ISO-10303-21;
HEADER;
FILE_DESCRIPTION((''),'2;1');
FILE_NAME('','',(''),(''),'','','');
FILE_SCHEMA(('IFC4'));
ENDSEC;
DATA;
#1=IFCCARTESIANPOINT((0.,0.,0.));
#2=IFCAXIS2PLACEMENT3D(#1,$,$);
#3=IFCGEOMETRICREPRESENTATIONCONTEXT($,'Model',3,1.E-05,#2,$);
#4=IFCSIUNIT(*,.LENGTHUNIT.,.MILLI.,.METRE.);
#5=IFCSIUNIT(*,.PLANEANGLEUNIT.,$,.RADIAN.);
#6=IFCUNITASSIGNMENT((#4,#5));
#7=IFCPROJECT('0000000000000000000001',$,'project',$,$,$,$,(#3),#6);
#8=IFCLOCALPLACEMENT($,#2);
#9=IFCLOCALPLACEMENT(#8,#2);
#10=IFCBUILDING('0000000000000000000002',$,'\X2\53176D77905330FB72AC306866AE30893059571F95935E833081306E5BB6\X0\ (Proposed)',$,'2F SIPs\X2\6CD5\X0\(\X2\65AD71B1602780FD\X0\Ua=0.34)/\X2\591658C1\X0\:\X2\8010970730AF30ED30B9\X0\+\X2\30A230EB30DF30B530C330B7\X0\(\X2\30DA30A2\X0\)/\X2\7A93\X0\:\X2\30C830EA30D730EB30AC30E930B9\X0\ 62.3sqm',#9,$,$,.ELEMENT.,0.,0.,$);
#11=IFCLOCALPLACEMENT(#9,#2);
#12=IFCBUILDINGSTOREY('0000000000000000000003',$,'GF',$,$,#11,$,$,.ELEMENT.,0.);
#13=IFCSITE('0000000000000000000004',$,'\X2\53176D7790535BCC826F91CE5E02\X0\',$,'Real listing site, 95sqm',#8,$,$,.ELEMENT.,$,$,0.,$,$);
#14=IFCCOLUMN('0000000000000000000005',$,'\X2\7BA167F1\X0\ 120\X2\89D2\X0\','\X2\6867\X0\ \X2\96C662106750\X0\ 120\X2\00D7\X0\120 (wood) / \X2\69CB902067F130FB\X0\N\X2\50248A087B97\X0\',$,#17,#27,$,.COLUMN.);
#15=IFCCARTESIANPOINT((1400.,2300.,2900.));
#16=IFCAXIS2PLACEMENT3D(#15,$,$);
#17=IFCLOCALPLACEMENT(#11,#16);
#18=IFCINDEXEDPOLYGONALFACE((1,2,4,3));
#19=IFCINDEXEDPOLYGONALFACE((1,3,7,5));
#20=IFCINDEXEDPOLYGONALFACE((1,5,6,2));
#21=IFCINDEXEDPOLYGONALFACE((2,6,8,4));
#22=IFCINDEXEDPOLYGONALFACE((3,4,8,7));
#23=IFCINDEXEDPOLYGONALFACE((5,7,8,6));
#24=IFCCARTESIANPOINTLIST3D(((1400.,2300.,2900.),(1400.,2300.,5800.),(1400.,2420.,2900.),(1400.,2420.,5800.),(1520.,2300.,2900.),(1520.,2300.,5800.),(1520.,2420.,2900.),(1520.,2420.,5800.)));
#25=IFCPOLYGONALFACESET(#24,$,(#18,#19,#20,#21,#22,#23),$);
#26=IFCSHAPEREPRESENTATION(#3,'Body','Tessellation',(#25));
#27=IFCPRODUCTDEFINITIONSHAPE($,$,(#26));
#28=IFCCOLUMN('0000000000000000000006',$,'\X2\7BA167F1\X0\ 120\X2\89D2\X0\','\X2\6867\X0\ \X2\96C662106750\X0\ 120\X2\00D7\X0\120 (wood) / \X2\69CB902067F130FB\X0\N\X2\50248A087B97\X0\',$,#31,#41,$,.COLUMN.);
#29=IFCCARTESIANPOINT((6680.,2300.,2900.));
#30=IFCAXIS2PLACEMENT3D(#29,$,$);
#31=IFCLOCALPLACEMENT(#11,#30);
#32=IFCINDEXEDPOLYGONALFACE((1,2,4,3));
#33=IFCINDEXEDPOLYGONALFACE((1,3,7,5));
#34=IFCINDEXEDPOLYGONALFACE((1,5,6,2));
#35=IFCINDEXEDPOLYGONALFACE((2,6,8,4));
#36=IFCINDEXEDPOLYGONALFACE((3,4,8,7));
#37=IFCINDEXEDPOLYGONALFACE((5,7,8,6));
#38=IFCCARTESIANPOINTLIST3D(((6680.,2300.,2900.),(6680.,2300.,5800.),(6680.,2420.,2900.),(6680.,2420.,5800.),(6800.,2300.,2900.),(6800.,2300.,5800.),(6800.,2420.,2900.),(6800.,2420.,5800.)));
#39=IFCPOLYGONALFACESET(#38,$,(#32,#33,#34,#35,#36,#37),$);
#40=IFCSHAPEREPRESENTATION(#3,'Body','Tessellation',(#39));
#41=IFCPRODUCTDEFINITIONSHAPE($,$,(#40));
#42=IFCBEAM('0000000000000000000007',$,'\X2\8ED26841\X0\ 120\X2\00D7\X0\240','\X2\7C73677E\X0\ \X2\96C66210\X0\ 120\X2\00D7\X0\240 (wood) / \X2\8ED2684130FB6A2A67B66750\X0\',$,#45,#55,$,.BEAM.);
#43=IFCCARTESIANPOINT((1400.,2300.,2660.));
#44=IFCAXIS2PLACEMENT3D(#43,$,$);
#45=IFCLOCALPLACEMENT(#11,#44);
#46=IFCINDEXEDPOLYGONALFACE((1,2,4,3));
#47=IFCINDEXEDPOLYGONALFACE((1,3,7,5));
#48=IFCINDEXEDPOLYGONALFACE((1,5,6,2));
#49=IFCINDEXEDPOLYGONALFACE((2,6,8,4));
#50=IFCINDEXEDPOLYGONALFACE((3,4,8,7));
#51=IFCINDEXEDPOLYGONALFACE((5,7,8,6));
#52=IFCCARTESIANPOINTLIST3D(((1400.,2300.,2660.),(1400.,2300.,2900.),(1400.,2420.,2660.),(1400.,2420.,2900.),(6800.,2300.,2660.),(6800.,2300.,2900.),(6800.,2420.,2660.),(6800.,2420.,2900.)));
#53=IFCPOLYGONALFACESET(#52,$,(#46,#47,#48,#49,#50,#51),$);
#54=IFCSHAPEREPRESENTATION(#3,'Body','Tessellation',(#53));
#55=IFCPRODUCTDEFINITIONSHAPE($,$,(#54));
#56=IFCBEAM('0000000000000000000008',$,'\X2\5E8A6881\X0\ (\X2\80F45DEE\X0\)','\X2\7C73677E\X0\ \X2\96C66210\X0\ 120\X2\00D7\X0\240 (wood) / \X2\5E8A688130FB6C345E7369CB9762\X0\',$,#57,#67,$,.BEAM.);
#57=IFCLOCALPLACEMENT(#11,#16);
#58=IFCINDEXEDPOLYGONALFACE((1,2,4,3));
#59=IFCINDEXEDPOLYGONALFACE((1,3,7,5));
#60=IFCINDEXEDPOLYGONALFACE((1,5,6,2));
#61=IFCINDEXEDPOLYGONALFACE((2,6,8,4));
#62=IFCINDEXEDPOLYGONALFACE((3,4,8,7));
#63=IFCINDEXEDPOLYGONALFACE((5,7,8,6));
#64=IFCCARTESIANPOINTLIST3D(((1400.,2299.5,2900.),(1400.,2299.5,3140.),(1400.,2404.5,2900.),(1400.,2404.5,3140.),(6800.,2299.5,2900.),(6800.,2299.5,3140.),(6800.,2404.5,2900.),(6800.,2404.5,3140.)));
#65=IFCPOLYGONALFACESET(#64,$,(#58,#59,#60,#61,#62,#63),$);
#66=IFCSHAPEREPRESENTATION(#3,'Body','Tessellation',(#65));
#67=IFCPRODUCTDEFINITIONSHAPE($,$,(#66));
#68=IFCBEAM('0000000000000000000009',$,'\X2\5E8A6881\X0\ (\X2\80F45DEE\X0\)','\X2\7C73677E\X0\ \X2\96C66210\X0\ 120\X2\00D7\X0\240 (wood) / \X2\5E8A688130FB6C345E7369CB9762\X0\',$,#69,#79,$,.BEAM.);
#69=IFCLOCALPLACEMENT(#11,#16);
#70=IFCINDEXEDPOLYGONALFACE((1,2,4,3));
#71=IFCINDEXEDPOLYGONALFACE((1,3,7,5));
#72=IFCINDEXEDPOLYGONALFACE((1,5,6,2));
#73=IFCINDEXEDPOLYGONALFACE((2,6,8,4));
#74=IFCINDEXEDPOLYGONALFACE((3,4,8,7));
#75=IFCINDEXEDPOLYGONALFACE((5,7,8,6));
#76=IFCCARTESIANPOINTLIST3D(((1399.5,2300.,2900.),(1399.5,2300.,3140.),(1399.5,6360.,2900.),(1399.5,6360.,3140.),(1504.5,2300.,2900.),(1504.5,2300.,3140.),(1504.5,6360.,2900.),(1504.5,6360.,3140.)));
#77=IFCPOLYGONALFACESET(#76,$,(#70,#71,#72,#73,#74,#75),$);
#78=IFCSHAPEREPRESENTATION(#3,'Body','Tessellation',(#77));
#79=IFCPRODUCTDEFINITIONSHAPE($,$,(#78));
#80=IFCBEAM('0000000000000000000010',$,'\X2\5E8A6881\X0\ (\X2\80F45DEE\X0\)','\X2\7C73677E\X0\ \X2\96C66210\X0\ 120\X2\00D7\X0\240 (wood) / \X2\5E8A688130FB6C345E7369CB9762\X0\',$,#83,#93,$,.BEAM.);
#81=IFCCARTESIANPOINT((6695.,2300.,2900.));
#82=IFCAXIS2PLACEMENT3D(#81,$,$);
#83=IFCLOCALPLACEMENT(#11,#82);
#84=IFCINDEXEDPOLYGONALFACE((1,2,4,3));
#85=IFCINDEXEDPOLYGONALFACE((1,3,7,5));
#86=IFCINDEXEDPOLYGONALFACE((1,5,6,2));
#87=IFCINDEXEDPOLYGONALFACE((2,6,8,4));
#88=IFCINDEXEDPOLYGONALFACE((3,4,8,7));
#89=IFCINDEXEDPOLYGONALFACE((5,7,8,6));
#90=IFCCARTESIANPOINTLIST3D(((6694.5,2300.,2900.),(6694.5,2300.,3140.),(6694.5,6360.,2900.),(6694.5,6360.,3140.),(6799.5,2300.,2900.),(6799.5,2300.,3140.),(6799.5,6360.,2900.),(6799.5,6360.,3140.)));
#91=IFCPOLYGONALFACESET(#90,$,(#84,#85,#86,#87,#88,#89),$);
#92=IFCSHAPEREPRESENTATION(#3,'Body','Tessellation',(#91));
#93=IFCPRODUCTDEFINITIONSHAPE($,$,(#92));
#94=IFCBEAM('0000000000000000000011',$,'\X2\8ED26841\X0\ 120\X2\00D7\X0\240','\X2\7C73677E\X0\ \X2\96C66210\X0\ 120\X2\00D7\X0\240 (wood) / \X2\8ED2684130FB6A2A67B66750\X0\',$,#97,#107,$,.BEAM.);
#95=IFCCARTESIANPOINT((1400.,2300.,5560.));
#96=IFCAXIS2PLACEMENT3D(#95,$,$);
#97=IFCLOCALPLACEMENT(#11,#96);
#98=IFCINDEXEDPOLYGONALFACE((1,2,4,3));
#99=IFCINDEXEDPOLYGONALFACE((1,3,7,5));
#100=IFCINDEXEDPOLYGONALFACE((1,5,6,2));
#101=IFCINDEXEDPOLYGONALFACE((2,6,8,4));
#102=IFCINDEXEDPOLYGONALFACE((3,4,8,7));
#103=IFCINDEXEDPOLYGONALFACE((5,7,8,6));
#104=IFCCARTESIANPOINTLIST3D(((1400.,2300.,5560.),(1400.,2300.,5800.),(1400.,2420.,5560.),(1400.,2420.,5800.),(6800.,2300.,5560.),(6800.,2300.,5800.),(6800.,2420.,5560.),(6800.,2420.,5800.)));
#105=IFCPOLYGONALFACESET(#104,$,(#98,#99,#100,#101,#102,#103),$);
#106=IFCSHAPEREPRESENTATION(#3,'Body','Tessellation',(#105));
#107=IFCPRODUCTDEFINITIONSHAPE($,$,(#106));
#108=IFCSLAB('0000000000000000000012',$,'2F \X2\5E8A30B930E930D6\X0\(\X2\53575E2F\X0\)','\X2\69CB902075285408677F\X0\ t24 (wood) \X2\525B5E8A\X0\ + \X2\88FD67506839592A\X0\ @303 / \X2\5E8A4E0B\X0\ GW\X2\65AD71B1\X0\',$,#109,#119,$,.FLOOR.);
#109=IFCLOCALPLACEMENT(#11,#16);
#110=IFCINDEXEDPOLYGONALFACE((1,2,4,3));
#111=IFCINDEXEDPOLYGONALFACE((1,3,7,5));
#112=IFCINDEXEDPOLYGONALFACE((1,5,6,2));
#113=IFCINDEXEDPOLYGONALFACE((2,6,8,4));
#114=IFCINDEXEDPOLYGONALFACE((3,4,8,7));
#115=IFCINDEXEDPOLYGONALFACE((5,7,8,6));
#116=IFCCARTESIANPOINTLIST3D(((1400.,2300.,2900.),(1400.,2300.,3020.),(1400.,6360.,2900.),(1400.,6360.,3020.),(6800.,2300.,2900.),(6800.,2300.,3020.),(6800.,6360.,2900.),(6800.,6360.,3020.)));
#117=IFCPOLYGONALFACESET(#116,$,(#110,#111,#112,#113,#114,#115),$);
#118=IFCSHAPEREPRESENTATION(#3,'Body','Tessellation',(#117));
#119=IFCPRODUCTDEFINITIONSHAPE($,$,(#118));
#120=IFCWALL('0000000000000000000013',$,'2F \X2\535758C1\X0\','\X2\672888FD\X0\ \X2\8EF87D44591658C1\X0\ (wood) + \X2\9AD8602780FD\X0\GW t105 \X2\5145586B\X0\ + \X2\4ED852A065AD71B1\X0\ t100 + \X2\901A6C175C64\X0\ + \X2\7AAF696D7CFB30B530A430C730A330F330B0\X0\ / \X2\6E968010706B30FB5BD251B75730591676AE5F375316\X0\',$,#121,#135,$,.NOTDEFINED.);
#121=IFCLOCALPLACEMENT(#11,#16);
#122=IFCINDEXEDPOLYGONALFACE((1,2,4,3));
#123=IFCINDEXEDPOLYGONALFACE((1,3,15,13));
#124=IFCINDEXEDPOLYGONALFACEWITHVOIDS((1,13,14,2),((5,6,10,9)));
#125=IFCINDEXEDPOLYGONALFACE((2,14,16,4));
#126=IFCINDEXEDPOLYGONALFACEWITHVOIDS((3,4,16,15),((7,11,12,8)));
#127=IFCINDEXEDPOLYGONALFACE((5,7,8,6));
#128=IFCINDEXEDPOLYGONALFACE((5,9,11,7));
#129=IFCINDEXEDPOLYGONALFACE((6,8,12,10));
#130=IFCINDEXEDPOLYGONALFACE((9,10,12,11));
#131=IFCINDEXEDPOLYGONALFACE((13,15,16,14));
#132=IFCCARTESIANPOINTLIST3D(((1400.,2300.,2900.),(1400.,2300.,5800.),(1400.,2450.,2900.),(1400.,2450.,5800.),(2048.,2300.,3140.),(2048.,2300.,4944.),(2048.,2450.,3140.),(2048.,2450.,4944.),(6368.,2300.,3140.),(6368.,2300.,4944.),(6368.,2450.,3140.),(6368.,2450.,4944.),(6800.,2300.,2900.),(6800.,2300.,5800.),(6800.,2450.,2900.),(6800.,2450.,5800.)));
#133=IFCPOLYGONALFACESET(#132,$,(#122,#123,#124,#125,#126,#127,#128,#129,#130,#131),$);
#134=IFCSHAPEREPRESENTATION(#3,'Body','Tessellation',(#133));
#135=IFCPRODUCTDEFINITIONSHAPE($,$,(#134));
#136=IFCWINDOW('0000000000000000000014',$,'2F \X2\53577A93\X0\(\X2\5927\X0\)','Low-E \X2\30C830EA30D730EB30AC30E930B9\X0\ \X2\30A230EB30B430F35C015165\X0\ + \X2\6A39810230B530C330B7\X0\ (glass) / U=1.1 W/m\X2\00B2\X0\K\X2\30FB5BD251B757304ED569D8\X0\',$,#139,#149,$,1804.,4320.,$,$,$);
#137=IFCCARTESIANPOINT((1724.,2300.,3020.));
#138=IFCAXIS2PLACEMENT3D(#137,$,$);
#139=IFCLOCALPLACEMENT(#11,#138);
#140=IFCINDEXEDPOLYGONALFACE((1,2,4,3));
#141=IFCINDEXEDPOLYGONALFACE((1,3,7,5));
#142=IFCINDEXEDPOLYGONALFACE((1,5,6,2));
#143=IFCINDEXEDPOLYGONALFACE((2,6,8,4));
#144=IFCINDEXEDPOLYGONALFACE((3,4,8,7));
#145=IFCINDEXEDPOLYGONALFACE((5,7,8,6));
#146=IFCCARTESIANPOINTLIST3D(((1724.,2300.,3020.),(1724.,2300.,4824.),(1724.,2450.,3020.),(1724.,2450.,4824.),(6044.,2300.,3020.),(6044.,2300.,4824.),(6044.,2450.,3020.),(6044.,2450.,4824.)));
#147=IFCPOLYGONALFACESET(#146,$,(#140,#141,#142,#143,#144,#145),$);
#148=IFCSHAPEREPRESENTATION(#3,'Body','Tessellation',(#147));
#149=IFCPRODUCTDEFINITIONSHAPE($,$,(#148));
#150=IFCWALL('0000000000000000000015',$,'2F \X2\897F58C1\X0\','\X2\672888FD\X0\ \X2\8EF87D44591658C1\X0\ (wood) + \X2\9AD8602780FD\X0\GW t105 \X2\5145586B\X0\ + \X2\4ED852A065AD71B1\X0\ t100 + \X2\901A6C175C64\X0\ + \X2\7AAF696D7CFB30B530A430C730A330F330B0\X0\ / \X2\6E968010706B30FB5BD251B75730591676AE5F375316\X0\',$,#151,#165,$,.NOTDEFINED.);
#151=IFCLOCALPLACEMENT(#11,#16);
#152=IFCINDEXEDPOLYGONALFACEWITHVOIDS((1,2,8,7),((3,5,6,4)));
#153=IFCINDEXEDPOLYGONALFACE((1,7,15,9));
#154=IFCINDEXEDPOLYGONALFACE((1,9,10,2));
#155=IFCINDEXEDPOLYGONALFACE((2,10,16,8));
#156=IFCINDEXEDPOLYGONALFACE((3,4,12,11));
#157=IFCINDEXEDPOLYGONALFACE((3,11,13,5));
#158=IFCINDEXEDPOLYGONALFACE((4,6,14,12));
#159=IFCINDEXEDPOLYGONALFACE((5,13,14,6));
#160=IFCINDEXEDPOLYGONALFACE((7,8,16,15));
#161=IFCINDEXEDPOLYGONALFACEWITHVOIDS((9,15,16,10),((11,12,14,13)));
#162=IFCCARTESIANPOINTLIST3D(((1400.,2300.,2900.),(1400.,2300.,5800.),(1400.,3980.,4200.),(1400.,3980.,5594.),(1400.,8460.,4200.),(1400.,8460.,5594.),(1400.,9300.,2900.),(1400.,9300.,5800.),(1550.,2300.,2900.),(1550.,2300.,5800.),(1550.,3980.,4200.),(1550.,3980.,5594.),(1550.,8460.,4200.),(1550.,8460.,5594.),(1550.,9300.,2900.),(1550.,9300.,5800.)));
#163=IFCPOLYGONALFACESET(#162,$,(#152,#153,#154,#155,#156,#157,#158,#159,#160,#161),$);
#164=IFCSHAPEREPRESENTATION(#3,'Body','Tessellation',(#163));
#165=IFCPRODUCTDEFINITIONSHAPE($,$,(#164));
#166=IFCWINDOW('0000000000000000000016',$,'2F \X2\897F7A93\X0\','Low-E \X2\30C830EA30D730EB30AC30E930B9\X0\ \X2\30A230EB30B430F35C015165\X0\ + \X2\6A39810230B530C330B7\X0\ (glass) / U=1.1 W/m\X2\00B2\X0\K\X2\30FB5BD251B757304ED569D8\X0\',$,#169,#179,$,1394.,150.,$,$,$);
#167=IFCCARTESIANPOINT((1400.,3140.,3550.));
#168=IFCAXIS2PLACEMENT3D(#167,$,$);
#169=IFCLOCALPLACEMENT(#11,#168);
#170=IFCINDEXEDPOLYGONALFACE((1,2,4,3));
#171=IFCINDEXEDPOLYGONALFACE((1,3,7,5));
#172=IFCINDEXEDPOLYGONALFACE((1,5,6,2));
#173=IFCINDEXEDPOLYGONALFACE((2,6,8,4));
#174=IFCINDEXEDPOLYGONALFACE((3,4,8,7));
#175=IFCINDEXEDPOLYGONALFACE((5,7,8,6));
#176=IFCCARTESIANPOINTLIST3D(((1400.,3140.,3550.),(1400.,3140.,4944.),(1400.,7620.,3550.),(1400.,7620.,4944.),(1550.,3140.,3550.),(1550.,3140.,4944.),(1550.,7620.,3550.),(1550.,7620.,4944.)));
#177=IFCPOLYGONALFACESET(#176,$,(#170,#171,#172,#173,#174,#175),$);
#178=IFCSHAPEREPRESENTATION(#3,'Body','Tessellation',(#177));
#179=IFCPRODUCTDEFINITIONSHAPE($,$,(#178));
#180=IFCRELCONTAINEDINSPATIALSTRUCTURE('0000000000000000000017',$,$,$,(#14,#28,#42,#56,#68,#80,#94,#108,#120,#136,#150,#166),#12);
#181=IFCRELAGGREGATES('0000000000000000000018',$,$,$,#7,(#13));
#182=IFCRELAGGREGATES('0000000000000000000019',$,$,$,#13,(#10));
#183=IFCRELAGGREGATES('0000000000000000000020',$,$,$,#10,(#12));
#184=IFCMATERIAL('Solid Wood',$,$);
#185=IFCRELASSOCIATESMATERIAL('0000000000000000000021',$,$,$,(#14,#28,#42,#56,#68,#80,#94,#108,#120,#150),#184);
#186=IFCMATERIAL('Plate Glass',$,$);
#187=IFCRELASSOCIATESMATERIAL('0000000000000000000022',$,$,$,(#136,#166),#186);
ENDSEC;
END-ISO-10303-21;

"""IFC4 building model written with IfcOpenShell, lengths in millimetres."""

from ifc_helpers import new_model, si_unit, frame, frame_2d, origin, place, context, project, spatial, rectangle, extrude, material, element, fill, save


model = new_model("IFC4")

# Units and contexts
model_context = context("Model", 3, precision=1e-05, world=origin())
ifc_project = project(units=[si_unit("LENGTHUNIT", "METRE", prefix="MILLI"), si_unit("PLANEANGLEUNIT", "RADIAN")], contexts=[model_context])

# Site, building, storey
site_placement = place(None, origin())
site = spatial("IfcSite", under=ifc_project, at=site_placement, Name="北海道富良野市", ObjectType="Real listing site, 95sqm", CompositionType="ELEMENT", RefElevation=0.0)
building_placement = place(site_placement, origin())
building = spatial("IfcBuilding", under=site, at=building_placement, Name="北海道・犬と暮らす土間広めの家 (Proposed)", ObjectType="2F SIPs法(断熱性能Ua=0.34)/外壁:耐震クロス+アルミサッシ(ペア)/窓:トリプルガラス 62.3sqm", CompositionType="ELEMENT", ElevationOfRefHeight=0.0, ElevationOfTerrain=0.0)
storey_placement = place(building_placement, origin())
storey = spatial("IfcBuildingStorey", under=building, at=storey_placement, Name="GF", CompositionType="ELEMENT", Elevation=0.0)

# Columns
ifc_material_1 = material(Name="Solid Wood")
column_1_placement = place(storey_placement, frame((1400.0, 2300.0, 2900.0)))
element("IfcColumn", 1, at=column_1_placement, inside=storey, material=ifc_material_1, Name="管柱 120角", Description="桧 集成材 120×120 (wood) / 構造柱・N値計算", PredefinedType="COLUMN", context=model_context, shape_type="SweptSolid", body=[
    extrude(rectangle(XDim=120.0, YDim=120.0, at=frame_2d((60.0, 60.0))), frame((1400.0, 2300.0, 2900.0)), (0.0, 0.0, 1.0), 2900.0),
])
column_2_placement = place(storey_placement, frame((6680.0, 2300.0, 2900.0)))
element("IfcColumn", 2, at=column_2_placement, inside=storey, material=ifc_material_1, Name="管柱 120角", Description="桧 集成材 120×120 (wood) / 構造柱・N値計算", PredefinedType="COLUMN", context=model_context, shape_type="SweptSolid", body=[
    extrude(rectangle(XDim=120.0, YDim=120.0, at=frame_2d((60.0, 60.0))), frame((6680.0, 2300.0, 2900.0)), (0.0, 0.0, 1.0), 2900.0),
])

# Beams
beam_1_placement = place(storey_placement, frame((1400.0, 2300.0, 2660.0)))
element("IfcBeam", 3, at=beam_1_placement, inside=storey, material=ifc_material_1, Name="軒桁 120×240", Description="米松 集成 120×240 (wood) / 軒桁・横架材", PredefinedType="BEAM", context=model_context, shape_type="SweptSolid", body=[
    extrude(rectangle(XDim=5400.0, YDim=120.0, at=frame_2d((2700.0, 60.0))), frame((1400.0, 2300.0, 2660.0)), (0.0, 0.0, 1.0), 240.0),
])
beam_2_placement = place(storey_placement, frame((1400.0, 2300.0, 2900.0)))
element("IfcBeam", 4, at=beam_2_placement, inside=storey, material=ifc_material_1, Name="床梁 (胴差)", Description="米松 集成 120×240 (wood) / 床梁・水平構面", PredefinedType="BEAM", context=model_context, shape_type="SweptSolid", body=[
    extrude(rectangle(XDim=5400.0, YDim=105.0, at=frame_2d((2700.0, 52.0))), frame((1400.0, 2300.0, 2900.0)), (0.0, 0.0, 1.0), 240.0),
])
beam_3_placement = place(storey_placement, frame((1400.0, 2300.0, 2900.0)))
element("IfcBeam", 5, at=beam_3_placement, inside=storey, material=ifc_material_1, Name="床梁 (胴差)", Description="米松 集成 120×240 (wood) / 床梁・水平構面", PredefinedType="BEAM", context=model_context, shape_type="SweptSolid", body=[
    extrude(rectangle(XDim=105.0, YDim=4060.0, at=frame_2d((52.0, 2030.0))), frame((1400.0, 2300.0, 2900.0)), (0.0, 0.0, 1.0), 240.0),
])
beam_4_placement = place(storey_placement, frame((6695.0, 2300.0, 2900.0)))
element("IfcBeam", 6, at=beam_4_placement, inside=storey, material=ifc_material_1, Name="床梁 (胴差)", Description="米松 集成 120×240 (wood) / 床梁・水平構面", PredefinedType="BEAM", context=model_context, shape_type="SweptSolid", body=[
    extrude(rectangle(XDim=105.0, YDim=4060.0, at=frame_2d((52.0, 2030.0))), frame((6695.0, 2300.0, 2900.0)), (0.0, 0.0, 1.0), 240.0),
])
beam_5_placement = place(storey_placement, frame((1400.0, 2300.0, 5560.0)))
element("IfcBeam", 7, at=beam_5_placement, inside=storey, material=ifc_material_1, Name="軒桁 120×240", Description="米松 集成 120×240 (wood) / 軒桁・横架材", PredefinedType="BEAM", context=model_context, shape_type="SweptSolid", body=[
    extrude(rectangle(XDim=5400.0, YDim=120.0, at=frame_2d((2700.0, 60.0))), frame((1400.0, 2300.0, 5560.0)), (0.0, 0.0, 1.0), 240.0),
])

# Slab
slab_placement = place(storey_placement, frame((1400.0, 2300.0, 2900.0)))
element("IfcSlab", 8, at=slab_placement, inside=storey, material=ifc_material_1, Name="2F 床スラブ(南帯)", Description="構造用合板 t24 (wood) 剛床 + 製材根太 @303 / 床下 GW断熱", PredefinedType="FLOOR", context=model_context, shape_type="SweptSolid", body=[
    extrude(rectangle(XDim=5400.0, YDim=4060.0, at=frame_2d((2700.0, 2030.0))), frame((1400.0, 2300.0, 2900.0)), (0.0, 0.0, 1.0), 120.0),
])

# Walls, openings, windows
wall_1_placement = place(storey_placement, frame((1400.0, 2300.0, 2900.0)))
wall_1 = element("IfcWall", 9, at=wall_1_placement, inside=storey, material=ifc_material_1, Name="2F 南壁", Description="木製 軸組外壁 (wood) + 高性能GW t105 充填 + 付加断熱 t100 + 通気層 + 窯業系サイディング / 準耐火・寒冷地外皮強化", PredefinedType="NOTDEFINED", context=model_context, shape_type="SweptSolid", body=[
    extrude(rectangle(XDim=5400.0, YDim=150.0, at=frame_2d((2700.0, 75.0))), frame((1400.0, 2300.0, 2900.0)), (0.0, 0.0, 1.0), 2900.0),
])
opening_1_placement = place(storey_placement, frame((1724.0, 2300.0, 3020.0)))
opening_1 = element("IfcOpeningElement", 10, at=opening_1_placement, cuts=wall_1, PredefinedType="NOTDEFINED", context=model_context, shape_type="SweptSolid", body=[
    extrude(rectangle(XDim=4320.0, YDim=150.0, at=frame_2d((2160.0, 75.0))), frame((1724.0, 2300.0, 3020.0)), (0.0, 0.0, 1.0), 1804.0),
])
ifc_material_2 = material(Name="Plate Glass")
window_1_placement = place(storey_placement, frame((1724.0, 2300.0, 3020.0)))
window_1 = element("IfcWindow", 11, at=window_1_placement, inside=storey, material=ifc_material_2, Name="2F 南窓(大)", Description="Low-E トリプルガラス アルゴン封入 + 樹脂サッシ (glass) / U=1.1 W/m²K・寒冷地仕様", OverallHeight=1804.0, OverallWidth=4320.0, context=model_context, shape_type="SweptSolid", body=[
    extrude(rectangle(XDim=4320.0, YDim=150.0, at=frame_2d((2160.0, 75.0))), frame((1724.0, 2300.0, 3020.0)), (0.0, 0.0, 1.0), 1804.0),
])
fill(opening_1, window_1)
wall_2_placement = place(storey_placement, frame((1400.0, 2300.0, 2900.0)))
wall_2 = element("IfcWall", 12, at=wall_2_placement, inside=storey, material=ifc_material_1, Name="2F 西壁", Description="木製 軸組外壁 (wood) + 高性能GW t105 充填 + 付加断熱 t100 + 通気層 + 窯業系サイディング / 準耐火・寒冷地外皮強化", PredefinedType="NOTDEFINED", context=model_context, shape_type="SweptSolid", body=[
    extrude(rectangle(XDim=150.0, YDim=7000.0, at=frame_2d((75.0, 3500.0))), frame((1400.0, 2300.0, 2900.0)), (0.0, 0.0, 1.0), 2900.0),
])
opening_2_placement = place(storey_placement, frame((1400.0, 3140.0, 3550.0)))
opening_2 = element("IfcOpeningElement", 13, at=opening_2_placement, cuts=wall_2, PredefinedType="NOTDEFINED", context=model_context, shape_type="SweptSolid", body=[
    extrude(rectangle(XDim=150.0, YDim=4480.0, at=frame_2d((75.0, 2240.0))), frame((1400.0, 3140.0, 3550.0)), (0.0, 0.0, 1.0), 1394.0),
])
window_2_placement = place(storey_placement, frame((1400.0, 3140.0, 3550.0)))
window_2 = element("IfcWindow", 14, at=window_2_placement, inside=storey, material=ifc_material_2, Name="2F 西窓", Description="Low-E トリプルガラス アルゴン封入 + 樹脂サッシ (glass) / U=1.1 W/m²K・寒冷地仕様", OverallHeight=1394.0, OverallWidth=150.0, context=model_context, shape_type="SweptSolid", body=[
    extrude(rectangle(XDim=150.0, YDim=4480.0, at=frame_2d((75.0, 2240.0))), frame((1400.0, 3140.0, 3550.0)), (0.0, 0.0, 1.0), 1394.0),
])
fill(opening_2, window_2)

save(model, "model.ifc")
